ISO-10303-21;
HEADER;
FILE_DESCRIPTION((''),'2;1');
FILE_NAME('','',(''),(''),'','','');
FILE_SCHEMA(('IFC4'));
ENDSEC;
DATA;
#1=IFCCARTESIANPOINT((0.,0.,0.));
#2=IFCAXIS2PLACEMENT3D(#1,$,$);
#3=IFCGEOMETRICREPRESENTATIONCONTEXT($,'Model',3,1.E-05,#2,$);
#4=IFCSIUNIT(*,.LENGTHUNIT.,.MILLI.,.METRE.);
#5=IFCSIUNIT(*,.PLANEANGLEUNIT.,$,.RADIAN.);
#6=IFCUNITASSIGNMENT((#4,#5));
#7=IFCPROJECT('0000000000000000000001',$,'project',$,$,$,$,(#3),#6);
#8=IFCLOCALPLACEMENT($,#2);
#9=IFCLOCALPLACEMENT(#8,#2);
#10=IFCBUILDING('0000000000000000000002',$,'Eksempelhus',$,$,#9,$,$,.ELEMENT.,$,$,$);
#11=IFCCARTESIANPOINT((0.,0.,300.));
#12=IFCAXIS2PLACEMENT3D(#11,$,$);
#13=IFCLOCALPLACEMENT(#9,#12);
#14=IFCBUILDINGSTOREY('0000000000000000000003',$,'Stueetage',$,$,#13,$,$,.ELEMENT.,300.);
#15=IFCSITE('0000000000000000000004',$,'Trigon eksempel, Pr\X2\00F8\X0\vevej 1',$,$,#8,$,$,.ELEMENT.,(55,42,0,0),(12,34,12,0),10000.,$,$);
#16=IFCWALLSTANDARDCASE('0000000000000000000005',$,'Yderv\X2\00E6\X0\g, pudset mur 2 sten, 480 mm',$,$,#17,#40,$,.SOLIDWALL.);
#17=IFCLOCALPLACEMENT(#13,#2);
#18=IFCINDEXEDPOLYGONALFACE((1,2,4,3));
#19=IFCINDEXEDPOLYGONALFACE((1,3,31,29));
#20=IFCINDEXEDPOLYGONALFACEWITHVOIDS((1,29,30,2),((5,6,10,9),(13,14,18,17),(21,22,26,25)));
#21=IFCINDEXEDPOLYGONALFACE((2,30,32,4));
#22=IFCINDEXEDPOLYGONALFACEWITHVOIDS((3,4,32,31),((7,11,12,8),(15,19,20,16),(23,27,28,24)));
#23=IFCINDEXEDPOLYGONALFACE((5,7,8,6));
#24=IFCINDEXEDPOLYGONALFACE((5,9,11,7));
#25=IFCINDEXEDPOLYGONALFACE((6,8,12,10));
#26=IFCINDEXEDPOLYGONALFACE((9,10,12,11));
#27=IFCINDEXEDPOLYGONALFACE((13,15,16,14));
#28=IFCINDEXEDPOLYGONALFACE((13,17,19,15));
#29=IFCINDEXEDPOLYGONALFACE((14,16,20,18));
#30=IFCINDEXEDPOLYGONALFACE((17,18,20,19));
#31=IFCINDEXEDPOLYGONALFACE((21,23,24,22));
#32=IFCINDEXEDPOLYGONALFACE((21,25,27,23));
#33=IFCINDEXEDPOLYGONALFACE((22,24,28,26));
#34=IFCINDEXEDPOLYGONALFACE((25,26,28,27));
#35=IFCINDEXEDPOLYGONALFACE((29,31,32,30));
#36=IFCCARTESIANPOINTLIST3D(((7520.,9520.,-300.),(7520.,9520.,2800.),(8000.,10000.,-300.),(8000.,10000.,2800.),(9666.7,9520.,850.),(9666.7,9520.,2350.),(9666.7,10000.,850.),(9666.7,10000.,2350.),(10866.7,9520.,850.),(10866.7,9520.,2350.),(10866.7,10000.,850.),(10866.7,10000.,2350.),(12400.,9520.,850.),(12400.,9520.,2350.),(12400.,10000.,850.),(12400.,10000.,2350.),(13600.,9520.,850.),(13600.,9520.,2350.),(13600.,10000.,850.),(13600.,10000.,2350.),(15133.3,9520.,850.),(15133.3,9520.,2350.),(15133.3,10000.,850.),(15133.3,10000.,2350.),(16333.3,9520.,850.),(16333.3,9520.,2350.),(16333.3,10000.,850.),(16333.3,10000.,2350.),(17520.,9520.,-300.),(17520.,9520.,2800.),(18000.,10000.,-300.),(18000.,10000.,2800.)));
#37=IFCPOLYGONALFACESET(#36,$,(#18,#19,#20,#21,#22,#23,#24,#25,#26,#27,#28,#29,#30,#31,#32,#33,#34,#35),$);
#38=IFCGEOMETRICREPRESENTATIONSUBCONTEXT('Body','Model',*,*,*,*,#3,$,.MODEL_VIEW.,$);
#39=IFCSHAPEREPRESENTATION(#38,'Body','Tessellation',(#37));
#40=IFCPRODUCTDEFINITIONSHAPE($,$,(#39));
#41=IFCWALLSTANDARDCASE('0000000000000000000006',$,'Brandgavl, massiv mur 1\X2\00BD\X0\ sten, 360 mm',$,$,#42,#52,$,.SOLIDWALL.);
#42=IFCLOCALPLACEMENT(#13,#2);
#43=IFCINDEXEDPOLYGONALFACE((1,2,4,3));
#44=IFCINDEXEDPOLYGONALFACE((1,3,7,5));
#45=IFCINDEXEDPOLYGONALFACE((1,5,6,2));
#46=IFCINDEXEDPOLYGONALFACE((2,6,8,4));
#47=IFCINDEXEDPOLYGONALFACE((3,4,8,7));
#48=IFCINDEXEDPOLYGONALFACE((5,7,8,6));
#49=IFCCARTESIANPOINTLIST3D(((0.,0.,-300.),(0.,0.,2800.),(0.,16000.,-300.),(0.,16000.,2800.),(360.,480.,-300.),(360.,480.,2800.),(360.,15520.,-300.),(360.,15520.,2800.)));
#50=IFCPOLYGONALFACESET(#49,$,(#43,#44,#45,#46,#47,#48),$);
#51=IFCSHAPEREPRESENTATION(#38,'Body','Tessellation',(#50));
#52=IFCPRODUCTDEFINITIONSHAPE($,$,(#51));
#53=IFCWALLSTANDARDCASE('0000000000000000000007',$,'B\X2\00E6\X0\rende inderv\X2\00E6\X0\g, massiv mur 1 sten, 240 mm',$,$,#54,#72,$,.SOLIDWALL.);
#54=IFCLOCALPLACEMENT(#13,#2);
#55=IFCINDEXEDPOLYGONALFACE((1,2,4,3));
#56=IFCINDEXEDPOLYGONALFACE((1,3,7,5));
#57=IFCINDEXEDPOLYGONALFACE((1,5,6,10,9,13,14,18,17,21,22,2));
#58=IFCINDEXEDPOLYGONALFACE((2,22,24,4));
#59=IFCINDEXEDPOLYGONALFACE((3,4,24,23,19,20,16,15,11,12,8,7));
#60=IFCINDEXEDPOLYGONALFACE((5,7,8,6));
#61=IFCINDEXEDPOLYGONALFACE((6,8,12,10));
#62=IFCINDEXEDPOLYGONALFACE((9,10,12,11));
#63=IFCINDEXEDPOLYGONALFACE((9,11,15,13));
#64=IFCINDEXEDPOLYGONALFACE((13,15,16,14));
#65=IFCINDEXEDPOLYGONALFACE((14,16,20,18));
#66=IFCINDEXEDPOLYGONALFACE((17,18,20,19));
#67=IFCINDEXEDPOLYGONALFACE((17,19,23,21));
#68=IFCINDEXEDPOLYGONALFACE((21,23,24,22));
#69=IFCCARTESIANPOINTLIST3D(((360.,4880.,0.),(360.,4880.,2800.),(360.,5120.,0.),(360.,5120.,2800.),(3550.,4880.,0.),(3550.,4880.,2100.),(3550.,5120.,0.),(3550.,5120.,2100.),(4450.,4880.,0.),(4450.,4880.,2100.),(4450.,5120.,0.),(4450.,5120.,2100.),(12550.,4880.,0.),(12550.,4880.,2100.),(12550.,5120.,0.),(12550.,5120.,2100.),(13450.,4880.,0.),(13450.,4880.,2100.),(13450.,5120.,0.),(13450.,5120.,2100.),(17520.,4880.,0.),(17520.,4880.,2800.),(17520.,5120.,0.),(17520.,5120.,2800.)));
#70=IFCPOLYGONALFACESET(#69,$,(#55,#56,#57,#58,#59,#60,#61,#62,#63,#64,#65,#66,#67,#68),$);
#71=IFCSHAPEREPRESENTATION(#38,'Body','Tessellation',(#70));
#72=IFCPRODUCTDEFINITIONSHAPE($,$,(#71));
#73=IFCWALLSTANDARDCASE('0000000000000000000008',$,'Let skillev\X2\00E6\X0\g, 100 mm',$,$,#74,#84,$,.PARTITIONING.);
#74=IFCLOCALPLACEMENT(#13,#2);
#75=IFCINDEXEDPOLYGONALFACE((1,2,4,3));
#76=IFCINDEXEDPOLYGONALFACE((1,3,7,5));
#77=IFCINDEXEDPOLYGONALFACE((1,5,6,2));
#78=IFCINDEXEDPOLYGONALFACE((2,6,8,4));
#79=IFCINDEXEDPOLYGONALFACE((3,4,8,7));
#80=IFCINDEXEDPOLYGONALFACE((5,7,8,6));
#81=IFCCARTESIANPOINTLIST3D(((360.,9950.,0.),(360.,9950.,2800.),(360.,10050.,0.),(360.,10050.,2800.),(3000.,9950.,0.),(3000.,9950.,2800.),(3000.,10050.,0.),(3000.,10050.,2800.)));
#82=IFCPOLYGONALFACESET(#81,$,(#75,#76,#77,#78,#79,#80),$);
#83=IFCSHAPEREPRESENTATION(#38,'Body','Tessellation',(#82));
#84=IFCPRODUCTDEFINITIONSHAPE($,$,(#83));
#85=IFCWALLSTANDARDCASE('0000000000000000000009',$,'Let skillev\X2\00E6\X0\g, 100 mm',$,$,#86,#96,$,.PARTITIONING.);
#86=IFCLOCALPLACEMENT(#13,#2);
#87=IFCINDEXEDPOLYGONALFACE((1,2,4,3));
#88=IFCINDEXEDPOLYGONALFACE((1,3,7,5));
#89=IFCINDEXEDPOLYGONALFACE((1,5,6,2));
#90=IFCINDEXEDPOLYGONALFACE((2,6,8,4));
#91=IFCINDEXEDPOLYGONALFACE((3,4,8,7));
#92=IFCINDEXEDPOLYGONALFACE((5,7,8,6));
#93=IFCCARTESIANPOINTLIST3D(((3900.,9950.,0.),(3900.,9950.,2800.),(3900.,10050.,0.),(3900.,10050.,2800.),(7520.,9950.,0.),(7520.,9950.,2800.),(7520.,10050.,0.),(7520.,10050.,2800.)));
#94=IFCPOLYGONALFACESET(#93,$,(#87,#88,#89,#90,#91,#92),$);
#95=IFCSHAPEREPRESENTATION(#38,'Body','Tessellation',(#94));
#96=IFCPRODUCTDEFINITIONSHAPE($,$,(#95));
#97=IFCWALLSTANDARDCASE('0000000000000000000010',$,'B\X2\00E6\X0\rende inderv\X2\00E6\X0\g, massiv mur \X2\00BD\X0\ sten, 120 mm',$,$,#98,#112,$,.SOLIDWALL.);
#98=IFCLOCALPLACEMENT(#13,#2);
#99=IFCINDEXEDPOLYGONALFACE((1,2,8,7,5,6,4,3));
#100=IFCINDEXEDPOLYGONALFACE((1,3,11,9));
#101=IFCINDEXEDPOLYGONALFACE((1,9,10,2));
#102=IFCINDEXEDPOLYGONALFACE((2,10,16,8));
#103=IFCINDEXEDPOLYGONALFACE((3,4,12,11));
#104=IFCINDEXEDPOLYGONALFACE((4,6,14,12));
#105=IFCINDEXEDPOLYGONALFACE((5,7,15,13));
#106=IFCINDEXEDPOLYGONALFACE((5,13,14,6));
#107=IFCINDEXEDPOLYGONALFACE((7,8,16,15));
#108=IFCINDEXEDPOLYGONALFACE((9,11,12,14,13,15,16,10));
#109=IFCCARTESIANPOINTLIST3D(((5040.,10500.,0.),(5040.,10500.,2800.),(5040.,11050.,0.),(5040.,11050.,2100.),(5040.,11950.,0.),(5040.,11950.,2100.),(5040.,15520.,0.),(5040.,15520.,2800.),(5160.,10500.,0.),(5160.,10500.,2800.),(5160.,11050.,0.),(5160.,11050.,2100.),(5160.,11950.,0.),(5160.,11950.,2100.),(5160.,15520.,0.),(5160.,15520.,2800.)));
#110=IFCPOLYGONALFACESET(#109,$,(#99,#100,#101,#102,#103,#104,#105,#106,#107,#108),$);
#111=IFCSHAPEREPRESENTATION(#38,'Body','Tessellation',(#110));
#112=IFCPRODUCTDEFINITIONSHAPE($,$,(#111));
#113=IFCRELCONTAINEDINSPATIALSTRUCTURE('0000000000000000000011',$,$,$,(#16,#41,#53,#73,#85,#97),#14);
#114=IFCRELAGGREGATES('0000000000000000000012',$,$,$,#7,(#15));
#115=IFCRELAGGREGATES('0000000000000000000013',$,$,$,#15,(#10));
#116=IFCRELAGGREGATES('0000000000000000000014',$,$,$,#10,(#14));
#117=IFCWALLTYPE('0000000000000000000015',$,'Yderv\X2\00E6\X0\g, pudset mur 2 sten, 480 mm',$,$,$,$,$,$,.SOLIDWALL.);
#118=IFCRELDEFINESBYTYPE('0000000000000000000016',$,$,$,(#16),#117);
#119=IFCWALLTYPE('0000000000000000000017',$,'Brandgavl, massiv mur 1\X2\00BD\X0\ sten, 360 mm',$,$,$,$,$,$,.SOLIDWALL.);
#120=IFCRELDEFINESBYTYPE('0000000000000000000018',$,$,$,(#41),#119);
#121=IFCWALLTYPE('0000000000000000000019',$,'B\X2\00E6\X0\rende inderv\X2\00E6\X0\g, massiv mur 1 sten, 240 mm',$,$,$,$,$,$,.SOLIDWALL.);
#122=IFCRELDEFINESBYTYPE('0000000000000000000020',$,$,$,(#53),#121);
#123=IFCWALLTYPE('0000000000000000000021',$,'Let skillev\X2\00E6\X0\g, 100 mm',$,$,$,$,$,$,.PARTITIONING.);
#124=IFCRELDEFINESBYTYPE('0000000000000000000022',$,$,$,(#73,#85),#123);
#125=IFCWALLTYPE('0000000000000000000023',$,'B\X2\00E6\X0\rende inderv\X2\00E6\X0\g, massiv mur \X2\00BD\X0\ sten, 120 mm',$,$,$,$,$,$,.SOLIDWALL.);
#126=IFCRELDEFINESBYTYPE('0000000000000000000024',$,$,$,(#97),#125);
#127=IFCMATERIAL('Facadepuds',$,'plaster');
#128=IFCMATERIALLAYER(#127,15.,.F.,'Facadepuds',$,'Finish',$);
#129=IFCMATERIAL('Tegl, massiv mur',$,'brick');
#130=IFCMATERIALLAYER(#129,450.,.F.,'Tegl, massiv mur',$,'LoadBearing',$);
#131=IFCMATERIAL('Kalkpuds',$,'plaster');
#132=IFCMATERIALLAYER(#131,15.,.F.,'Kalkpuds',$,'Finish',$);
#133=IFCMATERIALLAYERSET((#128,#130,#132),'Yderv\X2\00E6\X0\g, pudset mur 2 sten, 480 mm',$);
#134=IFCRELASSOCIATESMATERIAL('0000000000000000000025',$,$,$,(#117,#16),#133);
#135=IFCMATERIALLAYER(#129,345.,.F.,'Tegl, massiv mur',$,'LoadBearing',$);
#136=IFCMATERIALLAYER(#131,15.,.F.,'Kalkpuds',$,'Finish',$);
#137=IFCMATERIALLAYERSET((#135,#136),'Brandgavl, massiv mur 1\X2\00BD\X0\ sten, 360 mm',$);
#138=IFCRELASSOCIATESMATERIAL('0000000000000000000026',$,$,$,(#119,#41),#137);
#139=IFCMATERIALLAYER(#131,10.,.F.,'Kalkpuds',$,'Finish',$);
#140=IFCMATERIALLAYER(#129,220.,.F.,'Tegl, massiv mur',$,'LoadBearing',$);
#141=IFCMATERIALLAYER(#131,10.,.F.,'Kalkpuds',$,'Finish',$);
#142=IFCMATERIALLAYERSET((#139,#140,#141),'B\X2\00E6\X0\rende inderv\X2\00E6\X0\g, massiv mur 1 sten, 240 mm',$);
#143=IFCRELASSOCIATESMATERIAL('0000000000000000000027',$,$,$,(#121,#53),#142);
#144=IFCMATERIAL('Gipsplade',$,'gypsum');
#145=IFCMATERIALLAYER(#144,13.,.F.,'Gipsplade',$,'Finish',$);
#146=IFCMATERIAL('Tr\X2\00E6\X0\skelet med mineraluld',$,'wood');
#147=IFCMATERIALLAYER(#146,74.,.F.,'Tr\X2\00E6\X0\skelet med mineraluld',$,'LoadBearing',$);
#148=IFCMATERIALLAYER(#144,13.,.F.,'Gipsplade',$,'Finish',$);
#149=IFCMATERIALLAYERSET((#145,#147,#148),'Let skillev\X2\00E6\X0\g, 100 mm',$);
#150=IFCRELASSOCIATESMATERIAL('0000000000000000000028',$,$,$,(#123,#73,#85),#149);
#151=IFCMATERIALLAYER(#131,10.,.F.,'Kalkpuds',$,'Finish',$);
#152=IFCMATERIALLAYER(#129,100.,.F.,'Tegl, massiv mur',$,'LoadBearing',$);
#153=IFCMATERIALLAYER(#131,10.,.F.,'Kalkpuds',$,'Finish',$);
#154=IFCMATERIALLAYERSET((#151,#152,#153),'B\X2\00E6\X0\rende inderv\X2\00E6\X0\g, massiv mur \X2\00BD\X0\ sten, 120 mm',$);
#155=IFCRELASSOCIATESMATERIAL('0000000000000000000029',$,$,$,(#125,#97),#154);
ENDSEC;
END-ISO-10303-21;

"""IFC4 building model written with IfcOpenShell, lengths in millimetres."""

from ifc_helpers import new_model, si_unit, frame, origin, place, context, subcontext, project, spatial, polyline, rectangle, outline, extrude, material, layer, layer_set, layer_usage, type_object, element, save


model = new_model("IFC4")

# Units and contexts
model_context = context("Model", 3, precision=1e-05, world=origin())
body_context = subcontext(model_context, "Body", "Model", "MODEL_VIEW")
ifc_project = project(units=[si_unit("LENGTHUNIT", "METRE", prefix="MILLI"), si_unit("PLANEANGLEUNIT", "RADIAN")], contexts=[model_context])

# Site, building, storey
site_placement = place(None, origin())
site = spatial("IfcSite", under=ifc_project, at=site_placement, Name="Trigon eksempel, Prøvevej 1", CompositionType="ELEMENT", RefLatitude=(55, 42, 0, 0), RefLongitude=(12, 34, 12, 0), RefElevation=10000.0)
building_placement = place(site_placement, origin())
building = spatial("IfcBuilding", under=site, at=building_placement, Name="Eksempelhus", CompositionType="ELEMENT")
storey_placement = place(building_placement, frame((0.0, 0.0, 300.0)))
storey = spatial("IfcBuildingStorey", under=building, at=storey_placement, Name="Stueetage", CompositionType="ELEMENT", Elevation=300.0)

# Wall, openings
ifc_material_1 = material(Name="Tegl, massiv mur", Category="brick")
ifc_material_2 = material(Name="Kalkpuds", Category="plaster")
ifc_material_3 = material(Name="Facadepuds", Category="plaster")
ifc_layer_1 = layer(ifc_material_3, 15.0, ventilated=False, Name="Facadepuds", Category="Finish")
ifc_layer_2 = layer(ifc_material_1, 450.0, ventilated=False, Name="Tegl, massiv mur", Category="LoadBearing")
ifc_layer_3 = layer(ifc_material_2, 15.0, ventilated=False, Name="Kalkpuds", Category="Finish")
ifc_layer_set_1 = layer_set([ifc_layer_1, ifc_layer_2, ifc_layer_3], Name="Ydervæg, pudset mur 2 sten, 480 mm")
ifc_layer_usage_1 = layer_usage(ifc_layer_set_1, "AXIS2", "POSITIVE", 0.0)
wall_type_1 = type_object("IfcWallType", Name="Ydervæg, pudset mur 2 sten, 480 mm", PredefinedType="SOLIDWALL", material=ifc_layer_set_1)
wall_1_placement = place(storey_placement, frame((18000.0, 10000.0, -300.0), z_axis=(0.0, 0.0, 1.0), x_axis=(-1.0, 0.0, 0.0)))
wall_1 = element("IfcWallStandardCase", 1, at=wall_1_placement, inside=storey, type_object=wall_type_1, material=ifc_layer_usage_1, Name="Ydervæg, pudset mur 2 sten, 480 mm", PredefinedType="SOLIDWALL", context=body_context, shape_type="SweptSolid", body=[
    extrude(outline(polyline([(0.0, 0.0), (10000.0, 0.0), (10480.0, 480.0), (480.0, 480.0), (0.0, 0.0)])), origin(), (0.0, 0.0, 1.0), 3100.0),
])
opening_1_placement = place(wall_1_placement, frame((1666.7, 0.0, 1150.0)))
element("IfcOpeningElement", 2, at=opening_1_placement, cuts=wall_1, PredefinedType="OPENING", context=body_context, shape_type="SweptSolid", body=[
    extrude(rectangle(XDim=1200.0, YDim=1500.0), frame((600.0, 0.0, 750.0), z_axis=(0.0, 1.0, 0.0), x_axis=(1.0, 0.0, 0.0)), (0.0, 0.0, 1.0), 480.0),
])
opening_2_placement = place(wall_1_placement, frame((4400.0, 0.0, 1150.0)))
element("IfcOpeningElement", 3, at=opening_2_placement, cuts=wall_1, PredefinedType="OPENING", context=body_context, shape_type="SweptSolid", body=[
    extrude(rectangle(XDim=1200.0, YDim=1500.0), frame((600.0, 0.0, 750.0), z_axis=(0.0, 1.0, 0.0), x_axis=(1.0, 0.0, 0.0)), (0.0, 0.0, 1.0), 480.0),
])
opening_3_placement = place(wall_1_placement, frame((7133.3, 0.0, 1150.0)))
element("IfcOpeningElement", 4, at=opening_3_placement, cuts=wall_1, PredefinedType="OPENING", context=body_context, shape_type="SweptSolid", body=[
    extrude(rectangle(XDim=1200.0, YDim=1500.0), frame((600.0, 0.0, 750.0), z_axis=(0.0, 1.0, 0.0), x_axis=(1.0, 0.0, 0.0)), (0.0, 0.0, 1.0), 480.0),
])

# Wall
ifc_layer_4 = layer(ifc_material_1, 345.0, ventilated=False, Name="Tegl, massiv mur", Category="LoadBearing")
ifc_layer_5 = layer(ifc_material_2, 15.0, ventilated=False, Name="Kalkpuds", Category="Finish")
ifc_layer_set_2 = layer_set([ifc_layer_4, ifc_layer_5], Name="Brandgavl, massiv mur 1½ sten, 360 mm")
ifc_layer_usage_2 = layer_usage(ifc_layer_set_2, "AXIS2", "POSITIVE", 0.0)
wall_type_2 = type_object("IfcWallType", Name="Brandgavl, massiv mur 1½ sten, 360 mm", PredefinedType="SOLIDWALL", material=ifc_layer_set_2)
wall_2_placement = place(storey_placement, frame((0.0, 16000.0, -300.0), z_axis=(0.0, 0.0, 1.0), x_axis=(0.0, -1.0, 0.0)))
element("IfcWallStandardCase", 5, at=wall_2_placement, inside=storey, type_object=wall_type_2, material=ifc_layer_usage_2, Name="Brandgavl, massiv mur 1½ sten, 360 mm", PredefinedType="SOLIDWALL", context=body_context, shape_type="SweptSolid", body=[
    extrude(outline(polyline([(0.0, 0.0), (16000.0, 0.0), (15520.0, 360.0), (480.0, 360.0), (0.0, 0.0)])), origin(), (0.0, 0.0, 1.0), 3100.0),
])

# Wall, openings
ifc_layer_6 = layer(ifc_material_2, 10.0, ventilated=False, Name="Kalkpuds", Category="Finish")
ifc_layer_7 = layer(ifc_material_1, 220.0, ventilated=False, Name="Tegl, massiv mur", Category="LoadBearing")
ifc_layer_8 = layer(ifc_material_2, 10.0, ventilated=False, Name="Kalkpuds", Category="Finish")
ifc_layer_set_3 = layer_set([ifc_layer_6, ifc_layer_7, ifc_layer_8], Name="Bærende indervæg, massiv mur 1 sten, 240 mm")
ifc_layer_usage_3 = layer_usage(ifc_layer_set_3, "AXIS2", "POSITIVE", -120.0)
wall_type_3 = type_object("IfcWallType", Name="Bærende indervæg, massiv mur 1 sten, 240 mm", PredefinedType="SOLIDWALL", material=ifc_layer_set_3)
wall_3_placement = place(storey_placement, frame((360.0, 5000.0, 0.0)))
wall_3 = element("IfcWallStandardCase", 6, at=wall_3_placement, inside=storey, type_object=wall_type_3, material=ifc_layer_usage_3, Name="Bærende indervæg, massiv mur 1 sten, 240 mm", PredefinedType="SOLIDWALL", context=body_context, shape_type="SweptSolid", body=[
    extrude(outline(polyline([(0.0, -120.0), (17160.0, -120.0), (17160.0, 120.0), (0.0, 120.0), (0.0, -120.0)])), origin(), (0.0, 0.0, 1.0), 2800.0),
])
opening_4_placement = place(wall_3_placement, frame((3190.0, -120.0, 0.0)))
element("IfcOpeningElement", 7, at=opening_4_placement, cuts=wall_3, PredefinedType="OPENING", context=body_context, shape_type="SweptSolid", body=[
    extrude(rectangle(XDim=900.0, YDim=2100.0), frame((450.0, 0.0, 1050.0), z_axis=(0.0, 1.0, 0.0), x_axis=(1.0, 0.0, 0.0)), (0.0, 0.0, 1.0), 240.0),
])
opening_5_placement = place(wall_3_placement, frame((12190.0, -120.0, 0.0)))
element("IfcOpeningElement", 8, at=opening_5_placement, cuts=wall_3, PredefinedType="OPENING", context=body_context, shape_type="SweptSolid", body=[
    extrude(rectangle(XDim=900.0, YDim=2100.0), frame((450.0, 0.0, 1050.0), z_axis=(0.0, 1.0, 0.0), x_axis=(1.0, 0.0, 0.0)), (0.0, 0.0, 1.0), 240.0),
])

# Walls
ifc_material_4 = material(Name="Gipsplade", Category="gypsum")
ifc_layer_9 = layer(ifc_material_4, 13.0, ventilated=False, Name="Gipsplade", Category="Finish")
ifc_material_5 = material(Name="Træskelet med mineraluld", Category="wood")
ifc_layer_10 = layer(ifc_material_5, 74.0, ventilated=False, Name="Træskelet med mineraluld", Category="LoadBearing")
ifc_layer_11 = layer(ifc_material_4, 13.0, ventilated=False, Name="Gipsplade", Category="Finish")
ifc_layer_set_4 = layer_set([ifc_layer_9, ifc_layer_10, ifc_layer_11], Name="Let skillevæg, 100 mm")
ifc_layer_usage_4 = layer_usage(ifc_layer_set_4, "AXIS2", "POSITIVE", -50.0)
wall_type_4 = type_object("IfcWallType", Name="Let skillevæg, 100 mm", PredefinedType="PARTITIONING", material=ifc_layer_set_4)
wall_4_placement = place(storey_placement, frame((360.0, 10000.0, 0.0)))
element("IfcWallStandardCase", 9, at=wall_4_placement, inside=storey, type_object=wall_type_4, material=ifc_layer_usage_4, Name="Let skillevæg, 100 mm", PredefinedType="PARTITIONING", context=body_context, shape_type="SweptSolid", body=[
    extrude(outline(polyline([(0.0, -50.0), (2640.0, -50.0), (2640.0, 50.0), (0.0, 50.0), (0.0, -50.0)])), origin(), (0.0, 0.0, 1.0), 2800.0),
])
wall_5_placement = place(storey_placement, frame((3900.0, 10000.0, 0.0)))
element("IfcWallStandardCase", 10, at=wall_5_placement, inside=storey, type_object=wall_type_4, material=ifc_layer_usage_4, Name="Let skillevæg, 100 mm", PredefinedType="PARTITIONING", context=body_context, shape_type="SweptSolid", body=[
    extrude(outline(polyline([(0.0, -50.0), (3620.0, -50.0), (3620.0, 50.0), (0.0, 50.0), (0.0, -50.0)])), origin(), (0.0, 0.0, 1.0), 2800.0),
])

# Wall, opening
ifc_layer_12 = layer(ifc_material_2, 10.0, ventilated=False, Name="Kalkpuds", Category="Finish")
ifc_layer_13 = layer(ifc_material_1, 100.0, ventilated=False, Name="Tegl, massiv mur", Category="LoadBearing")
ifc_layer_14 = layer(ifc_material_2, 10.0, ventilated=False, Name="Kalkpuds", Category="Finish")
ifc_layer_set_5 = layer_set([ifc_layer_12, ifc_layer_13, ifc_layer_14], Name="Bærende indervæg, massiv mur ½ sten, 120 mm")
ifc_layer_usage_5 = layer_usage(ifc_layer_set_5, "AXIS2", "POSITIVE", -60.0)
wall_type_5 = type_object("IfcWallType", Name="Bærende indervæg, massiv mur ½ sten, 120 mm", PredefinedType="SOLIDWALL", material=ifc_layer_set_5)
wall_6_placement = place(storey_placement, frame((5100.0, 10500.0, 0.0), z_axis=(0.0, 0.0, 1.0), x_axis=(0.0, 1.0, 0.0)))
wall_6 = element("IfcWallStandardCase", 11, at=wall_6_placement, inside=storey, type_object=wall_type_5, material=ifc_layer_usage_5, Name="Bærende indervæg, massiv mur ½ sten, 120 mm", PredefinedType="SOLIDWALL", context=body_context, shape_type="SweptSolid", body=[
    extrude(outline(polyline([(0.0, -60.0), (5020.0, -60.0), (5020.0, 60.0), (0.0, 60.0), (0.0, -60.0)])), origin(), (0.0, 0.0, 1.0), 2800.0),
])
opening_6_placement = place(wall_6_placement, frame((550.0, -60.0, 0.0)))
element("IfcOpeningElement", 12, at=opening_6_placement, cuts=wall_6, PredefinedType="OPENING", context=body_context, shape_type="SweptSolid", body=[
    extrude(rectangle(XDim=900.0, YDim=2100.0), frame((450.0, 0.0, 1050.0), z_axis=(0.0, 1.0, 0.0), x_axis=(1.0, 0.0, 0.0)), (0.0, 0.0, 1.0), 120.0),
])

save(model, "model.ifc")
